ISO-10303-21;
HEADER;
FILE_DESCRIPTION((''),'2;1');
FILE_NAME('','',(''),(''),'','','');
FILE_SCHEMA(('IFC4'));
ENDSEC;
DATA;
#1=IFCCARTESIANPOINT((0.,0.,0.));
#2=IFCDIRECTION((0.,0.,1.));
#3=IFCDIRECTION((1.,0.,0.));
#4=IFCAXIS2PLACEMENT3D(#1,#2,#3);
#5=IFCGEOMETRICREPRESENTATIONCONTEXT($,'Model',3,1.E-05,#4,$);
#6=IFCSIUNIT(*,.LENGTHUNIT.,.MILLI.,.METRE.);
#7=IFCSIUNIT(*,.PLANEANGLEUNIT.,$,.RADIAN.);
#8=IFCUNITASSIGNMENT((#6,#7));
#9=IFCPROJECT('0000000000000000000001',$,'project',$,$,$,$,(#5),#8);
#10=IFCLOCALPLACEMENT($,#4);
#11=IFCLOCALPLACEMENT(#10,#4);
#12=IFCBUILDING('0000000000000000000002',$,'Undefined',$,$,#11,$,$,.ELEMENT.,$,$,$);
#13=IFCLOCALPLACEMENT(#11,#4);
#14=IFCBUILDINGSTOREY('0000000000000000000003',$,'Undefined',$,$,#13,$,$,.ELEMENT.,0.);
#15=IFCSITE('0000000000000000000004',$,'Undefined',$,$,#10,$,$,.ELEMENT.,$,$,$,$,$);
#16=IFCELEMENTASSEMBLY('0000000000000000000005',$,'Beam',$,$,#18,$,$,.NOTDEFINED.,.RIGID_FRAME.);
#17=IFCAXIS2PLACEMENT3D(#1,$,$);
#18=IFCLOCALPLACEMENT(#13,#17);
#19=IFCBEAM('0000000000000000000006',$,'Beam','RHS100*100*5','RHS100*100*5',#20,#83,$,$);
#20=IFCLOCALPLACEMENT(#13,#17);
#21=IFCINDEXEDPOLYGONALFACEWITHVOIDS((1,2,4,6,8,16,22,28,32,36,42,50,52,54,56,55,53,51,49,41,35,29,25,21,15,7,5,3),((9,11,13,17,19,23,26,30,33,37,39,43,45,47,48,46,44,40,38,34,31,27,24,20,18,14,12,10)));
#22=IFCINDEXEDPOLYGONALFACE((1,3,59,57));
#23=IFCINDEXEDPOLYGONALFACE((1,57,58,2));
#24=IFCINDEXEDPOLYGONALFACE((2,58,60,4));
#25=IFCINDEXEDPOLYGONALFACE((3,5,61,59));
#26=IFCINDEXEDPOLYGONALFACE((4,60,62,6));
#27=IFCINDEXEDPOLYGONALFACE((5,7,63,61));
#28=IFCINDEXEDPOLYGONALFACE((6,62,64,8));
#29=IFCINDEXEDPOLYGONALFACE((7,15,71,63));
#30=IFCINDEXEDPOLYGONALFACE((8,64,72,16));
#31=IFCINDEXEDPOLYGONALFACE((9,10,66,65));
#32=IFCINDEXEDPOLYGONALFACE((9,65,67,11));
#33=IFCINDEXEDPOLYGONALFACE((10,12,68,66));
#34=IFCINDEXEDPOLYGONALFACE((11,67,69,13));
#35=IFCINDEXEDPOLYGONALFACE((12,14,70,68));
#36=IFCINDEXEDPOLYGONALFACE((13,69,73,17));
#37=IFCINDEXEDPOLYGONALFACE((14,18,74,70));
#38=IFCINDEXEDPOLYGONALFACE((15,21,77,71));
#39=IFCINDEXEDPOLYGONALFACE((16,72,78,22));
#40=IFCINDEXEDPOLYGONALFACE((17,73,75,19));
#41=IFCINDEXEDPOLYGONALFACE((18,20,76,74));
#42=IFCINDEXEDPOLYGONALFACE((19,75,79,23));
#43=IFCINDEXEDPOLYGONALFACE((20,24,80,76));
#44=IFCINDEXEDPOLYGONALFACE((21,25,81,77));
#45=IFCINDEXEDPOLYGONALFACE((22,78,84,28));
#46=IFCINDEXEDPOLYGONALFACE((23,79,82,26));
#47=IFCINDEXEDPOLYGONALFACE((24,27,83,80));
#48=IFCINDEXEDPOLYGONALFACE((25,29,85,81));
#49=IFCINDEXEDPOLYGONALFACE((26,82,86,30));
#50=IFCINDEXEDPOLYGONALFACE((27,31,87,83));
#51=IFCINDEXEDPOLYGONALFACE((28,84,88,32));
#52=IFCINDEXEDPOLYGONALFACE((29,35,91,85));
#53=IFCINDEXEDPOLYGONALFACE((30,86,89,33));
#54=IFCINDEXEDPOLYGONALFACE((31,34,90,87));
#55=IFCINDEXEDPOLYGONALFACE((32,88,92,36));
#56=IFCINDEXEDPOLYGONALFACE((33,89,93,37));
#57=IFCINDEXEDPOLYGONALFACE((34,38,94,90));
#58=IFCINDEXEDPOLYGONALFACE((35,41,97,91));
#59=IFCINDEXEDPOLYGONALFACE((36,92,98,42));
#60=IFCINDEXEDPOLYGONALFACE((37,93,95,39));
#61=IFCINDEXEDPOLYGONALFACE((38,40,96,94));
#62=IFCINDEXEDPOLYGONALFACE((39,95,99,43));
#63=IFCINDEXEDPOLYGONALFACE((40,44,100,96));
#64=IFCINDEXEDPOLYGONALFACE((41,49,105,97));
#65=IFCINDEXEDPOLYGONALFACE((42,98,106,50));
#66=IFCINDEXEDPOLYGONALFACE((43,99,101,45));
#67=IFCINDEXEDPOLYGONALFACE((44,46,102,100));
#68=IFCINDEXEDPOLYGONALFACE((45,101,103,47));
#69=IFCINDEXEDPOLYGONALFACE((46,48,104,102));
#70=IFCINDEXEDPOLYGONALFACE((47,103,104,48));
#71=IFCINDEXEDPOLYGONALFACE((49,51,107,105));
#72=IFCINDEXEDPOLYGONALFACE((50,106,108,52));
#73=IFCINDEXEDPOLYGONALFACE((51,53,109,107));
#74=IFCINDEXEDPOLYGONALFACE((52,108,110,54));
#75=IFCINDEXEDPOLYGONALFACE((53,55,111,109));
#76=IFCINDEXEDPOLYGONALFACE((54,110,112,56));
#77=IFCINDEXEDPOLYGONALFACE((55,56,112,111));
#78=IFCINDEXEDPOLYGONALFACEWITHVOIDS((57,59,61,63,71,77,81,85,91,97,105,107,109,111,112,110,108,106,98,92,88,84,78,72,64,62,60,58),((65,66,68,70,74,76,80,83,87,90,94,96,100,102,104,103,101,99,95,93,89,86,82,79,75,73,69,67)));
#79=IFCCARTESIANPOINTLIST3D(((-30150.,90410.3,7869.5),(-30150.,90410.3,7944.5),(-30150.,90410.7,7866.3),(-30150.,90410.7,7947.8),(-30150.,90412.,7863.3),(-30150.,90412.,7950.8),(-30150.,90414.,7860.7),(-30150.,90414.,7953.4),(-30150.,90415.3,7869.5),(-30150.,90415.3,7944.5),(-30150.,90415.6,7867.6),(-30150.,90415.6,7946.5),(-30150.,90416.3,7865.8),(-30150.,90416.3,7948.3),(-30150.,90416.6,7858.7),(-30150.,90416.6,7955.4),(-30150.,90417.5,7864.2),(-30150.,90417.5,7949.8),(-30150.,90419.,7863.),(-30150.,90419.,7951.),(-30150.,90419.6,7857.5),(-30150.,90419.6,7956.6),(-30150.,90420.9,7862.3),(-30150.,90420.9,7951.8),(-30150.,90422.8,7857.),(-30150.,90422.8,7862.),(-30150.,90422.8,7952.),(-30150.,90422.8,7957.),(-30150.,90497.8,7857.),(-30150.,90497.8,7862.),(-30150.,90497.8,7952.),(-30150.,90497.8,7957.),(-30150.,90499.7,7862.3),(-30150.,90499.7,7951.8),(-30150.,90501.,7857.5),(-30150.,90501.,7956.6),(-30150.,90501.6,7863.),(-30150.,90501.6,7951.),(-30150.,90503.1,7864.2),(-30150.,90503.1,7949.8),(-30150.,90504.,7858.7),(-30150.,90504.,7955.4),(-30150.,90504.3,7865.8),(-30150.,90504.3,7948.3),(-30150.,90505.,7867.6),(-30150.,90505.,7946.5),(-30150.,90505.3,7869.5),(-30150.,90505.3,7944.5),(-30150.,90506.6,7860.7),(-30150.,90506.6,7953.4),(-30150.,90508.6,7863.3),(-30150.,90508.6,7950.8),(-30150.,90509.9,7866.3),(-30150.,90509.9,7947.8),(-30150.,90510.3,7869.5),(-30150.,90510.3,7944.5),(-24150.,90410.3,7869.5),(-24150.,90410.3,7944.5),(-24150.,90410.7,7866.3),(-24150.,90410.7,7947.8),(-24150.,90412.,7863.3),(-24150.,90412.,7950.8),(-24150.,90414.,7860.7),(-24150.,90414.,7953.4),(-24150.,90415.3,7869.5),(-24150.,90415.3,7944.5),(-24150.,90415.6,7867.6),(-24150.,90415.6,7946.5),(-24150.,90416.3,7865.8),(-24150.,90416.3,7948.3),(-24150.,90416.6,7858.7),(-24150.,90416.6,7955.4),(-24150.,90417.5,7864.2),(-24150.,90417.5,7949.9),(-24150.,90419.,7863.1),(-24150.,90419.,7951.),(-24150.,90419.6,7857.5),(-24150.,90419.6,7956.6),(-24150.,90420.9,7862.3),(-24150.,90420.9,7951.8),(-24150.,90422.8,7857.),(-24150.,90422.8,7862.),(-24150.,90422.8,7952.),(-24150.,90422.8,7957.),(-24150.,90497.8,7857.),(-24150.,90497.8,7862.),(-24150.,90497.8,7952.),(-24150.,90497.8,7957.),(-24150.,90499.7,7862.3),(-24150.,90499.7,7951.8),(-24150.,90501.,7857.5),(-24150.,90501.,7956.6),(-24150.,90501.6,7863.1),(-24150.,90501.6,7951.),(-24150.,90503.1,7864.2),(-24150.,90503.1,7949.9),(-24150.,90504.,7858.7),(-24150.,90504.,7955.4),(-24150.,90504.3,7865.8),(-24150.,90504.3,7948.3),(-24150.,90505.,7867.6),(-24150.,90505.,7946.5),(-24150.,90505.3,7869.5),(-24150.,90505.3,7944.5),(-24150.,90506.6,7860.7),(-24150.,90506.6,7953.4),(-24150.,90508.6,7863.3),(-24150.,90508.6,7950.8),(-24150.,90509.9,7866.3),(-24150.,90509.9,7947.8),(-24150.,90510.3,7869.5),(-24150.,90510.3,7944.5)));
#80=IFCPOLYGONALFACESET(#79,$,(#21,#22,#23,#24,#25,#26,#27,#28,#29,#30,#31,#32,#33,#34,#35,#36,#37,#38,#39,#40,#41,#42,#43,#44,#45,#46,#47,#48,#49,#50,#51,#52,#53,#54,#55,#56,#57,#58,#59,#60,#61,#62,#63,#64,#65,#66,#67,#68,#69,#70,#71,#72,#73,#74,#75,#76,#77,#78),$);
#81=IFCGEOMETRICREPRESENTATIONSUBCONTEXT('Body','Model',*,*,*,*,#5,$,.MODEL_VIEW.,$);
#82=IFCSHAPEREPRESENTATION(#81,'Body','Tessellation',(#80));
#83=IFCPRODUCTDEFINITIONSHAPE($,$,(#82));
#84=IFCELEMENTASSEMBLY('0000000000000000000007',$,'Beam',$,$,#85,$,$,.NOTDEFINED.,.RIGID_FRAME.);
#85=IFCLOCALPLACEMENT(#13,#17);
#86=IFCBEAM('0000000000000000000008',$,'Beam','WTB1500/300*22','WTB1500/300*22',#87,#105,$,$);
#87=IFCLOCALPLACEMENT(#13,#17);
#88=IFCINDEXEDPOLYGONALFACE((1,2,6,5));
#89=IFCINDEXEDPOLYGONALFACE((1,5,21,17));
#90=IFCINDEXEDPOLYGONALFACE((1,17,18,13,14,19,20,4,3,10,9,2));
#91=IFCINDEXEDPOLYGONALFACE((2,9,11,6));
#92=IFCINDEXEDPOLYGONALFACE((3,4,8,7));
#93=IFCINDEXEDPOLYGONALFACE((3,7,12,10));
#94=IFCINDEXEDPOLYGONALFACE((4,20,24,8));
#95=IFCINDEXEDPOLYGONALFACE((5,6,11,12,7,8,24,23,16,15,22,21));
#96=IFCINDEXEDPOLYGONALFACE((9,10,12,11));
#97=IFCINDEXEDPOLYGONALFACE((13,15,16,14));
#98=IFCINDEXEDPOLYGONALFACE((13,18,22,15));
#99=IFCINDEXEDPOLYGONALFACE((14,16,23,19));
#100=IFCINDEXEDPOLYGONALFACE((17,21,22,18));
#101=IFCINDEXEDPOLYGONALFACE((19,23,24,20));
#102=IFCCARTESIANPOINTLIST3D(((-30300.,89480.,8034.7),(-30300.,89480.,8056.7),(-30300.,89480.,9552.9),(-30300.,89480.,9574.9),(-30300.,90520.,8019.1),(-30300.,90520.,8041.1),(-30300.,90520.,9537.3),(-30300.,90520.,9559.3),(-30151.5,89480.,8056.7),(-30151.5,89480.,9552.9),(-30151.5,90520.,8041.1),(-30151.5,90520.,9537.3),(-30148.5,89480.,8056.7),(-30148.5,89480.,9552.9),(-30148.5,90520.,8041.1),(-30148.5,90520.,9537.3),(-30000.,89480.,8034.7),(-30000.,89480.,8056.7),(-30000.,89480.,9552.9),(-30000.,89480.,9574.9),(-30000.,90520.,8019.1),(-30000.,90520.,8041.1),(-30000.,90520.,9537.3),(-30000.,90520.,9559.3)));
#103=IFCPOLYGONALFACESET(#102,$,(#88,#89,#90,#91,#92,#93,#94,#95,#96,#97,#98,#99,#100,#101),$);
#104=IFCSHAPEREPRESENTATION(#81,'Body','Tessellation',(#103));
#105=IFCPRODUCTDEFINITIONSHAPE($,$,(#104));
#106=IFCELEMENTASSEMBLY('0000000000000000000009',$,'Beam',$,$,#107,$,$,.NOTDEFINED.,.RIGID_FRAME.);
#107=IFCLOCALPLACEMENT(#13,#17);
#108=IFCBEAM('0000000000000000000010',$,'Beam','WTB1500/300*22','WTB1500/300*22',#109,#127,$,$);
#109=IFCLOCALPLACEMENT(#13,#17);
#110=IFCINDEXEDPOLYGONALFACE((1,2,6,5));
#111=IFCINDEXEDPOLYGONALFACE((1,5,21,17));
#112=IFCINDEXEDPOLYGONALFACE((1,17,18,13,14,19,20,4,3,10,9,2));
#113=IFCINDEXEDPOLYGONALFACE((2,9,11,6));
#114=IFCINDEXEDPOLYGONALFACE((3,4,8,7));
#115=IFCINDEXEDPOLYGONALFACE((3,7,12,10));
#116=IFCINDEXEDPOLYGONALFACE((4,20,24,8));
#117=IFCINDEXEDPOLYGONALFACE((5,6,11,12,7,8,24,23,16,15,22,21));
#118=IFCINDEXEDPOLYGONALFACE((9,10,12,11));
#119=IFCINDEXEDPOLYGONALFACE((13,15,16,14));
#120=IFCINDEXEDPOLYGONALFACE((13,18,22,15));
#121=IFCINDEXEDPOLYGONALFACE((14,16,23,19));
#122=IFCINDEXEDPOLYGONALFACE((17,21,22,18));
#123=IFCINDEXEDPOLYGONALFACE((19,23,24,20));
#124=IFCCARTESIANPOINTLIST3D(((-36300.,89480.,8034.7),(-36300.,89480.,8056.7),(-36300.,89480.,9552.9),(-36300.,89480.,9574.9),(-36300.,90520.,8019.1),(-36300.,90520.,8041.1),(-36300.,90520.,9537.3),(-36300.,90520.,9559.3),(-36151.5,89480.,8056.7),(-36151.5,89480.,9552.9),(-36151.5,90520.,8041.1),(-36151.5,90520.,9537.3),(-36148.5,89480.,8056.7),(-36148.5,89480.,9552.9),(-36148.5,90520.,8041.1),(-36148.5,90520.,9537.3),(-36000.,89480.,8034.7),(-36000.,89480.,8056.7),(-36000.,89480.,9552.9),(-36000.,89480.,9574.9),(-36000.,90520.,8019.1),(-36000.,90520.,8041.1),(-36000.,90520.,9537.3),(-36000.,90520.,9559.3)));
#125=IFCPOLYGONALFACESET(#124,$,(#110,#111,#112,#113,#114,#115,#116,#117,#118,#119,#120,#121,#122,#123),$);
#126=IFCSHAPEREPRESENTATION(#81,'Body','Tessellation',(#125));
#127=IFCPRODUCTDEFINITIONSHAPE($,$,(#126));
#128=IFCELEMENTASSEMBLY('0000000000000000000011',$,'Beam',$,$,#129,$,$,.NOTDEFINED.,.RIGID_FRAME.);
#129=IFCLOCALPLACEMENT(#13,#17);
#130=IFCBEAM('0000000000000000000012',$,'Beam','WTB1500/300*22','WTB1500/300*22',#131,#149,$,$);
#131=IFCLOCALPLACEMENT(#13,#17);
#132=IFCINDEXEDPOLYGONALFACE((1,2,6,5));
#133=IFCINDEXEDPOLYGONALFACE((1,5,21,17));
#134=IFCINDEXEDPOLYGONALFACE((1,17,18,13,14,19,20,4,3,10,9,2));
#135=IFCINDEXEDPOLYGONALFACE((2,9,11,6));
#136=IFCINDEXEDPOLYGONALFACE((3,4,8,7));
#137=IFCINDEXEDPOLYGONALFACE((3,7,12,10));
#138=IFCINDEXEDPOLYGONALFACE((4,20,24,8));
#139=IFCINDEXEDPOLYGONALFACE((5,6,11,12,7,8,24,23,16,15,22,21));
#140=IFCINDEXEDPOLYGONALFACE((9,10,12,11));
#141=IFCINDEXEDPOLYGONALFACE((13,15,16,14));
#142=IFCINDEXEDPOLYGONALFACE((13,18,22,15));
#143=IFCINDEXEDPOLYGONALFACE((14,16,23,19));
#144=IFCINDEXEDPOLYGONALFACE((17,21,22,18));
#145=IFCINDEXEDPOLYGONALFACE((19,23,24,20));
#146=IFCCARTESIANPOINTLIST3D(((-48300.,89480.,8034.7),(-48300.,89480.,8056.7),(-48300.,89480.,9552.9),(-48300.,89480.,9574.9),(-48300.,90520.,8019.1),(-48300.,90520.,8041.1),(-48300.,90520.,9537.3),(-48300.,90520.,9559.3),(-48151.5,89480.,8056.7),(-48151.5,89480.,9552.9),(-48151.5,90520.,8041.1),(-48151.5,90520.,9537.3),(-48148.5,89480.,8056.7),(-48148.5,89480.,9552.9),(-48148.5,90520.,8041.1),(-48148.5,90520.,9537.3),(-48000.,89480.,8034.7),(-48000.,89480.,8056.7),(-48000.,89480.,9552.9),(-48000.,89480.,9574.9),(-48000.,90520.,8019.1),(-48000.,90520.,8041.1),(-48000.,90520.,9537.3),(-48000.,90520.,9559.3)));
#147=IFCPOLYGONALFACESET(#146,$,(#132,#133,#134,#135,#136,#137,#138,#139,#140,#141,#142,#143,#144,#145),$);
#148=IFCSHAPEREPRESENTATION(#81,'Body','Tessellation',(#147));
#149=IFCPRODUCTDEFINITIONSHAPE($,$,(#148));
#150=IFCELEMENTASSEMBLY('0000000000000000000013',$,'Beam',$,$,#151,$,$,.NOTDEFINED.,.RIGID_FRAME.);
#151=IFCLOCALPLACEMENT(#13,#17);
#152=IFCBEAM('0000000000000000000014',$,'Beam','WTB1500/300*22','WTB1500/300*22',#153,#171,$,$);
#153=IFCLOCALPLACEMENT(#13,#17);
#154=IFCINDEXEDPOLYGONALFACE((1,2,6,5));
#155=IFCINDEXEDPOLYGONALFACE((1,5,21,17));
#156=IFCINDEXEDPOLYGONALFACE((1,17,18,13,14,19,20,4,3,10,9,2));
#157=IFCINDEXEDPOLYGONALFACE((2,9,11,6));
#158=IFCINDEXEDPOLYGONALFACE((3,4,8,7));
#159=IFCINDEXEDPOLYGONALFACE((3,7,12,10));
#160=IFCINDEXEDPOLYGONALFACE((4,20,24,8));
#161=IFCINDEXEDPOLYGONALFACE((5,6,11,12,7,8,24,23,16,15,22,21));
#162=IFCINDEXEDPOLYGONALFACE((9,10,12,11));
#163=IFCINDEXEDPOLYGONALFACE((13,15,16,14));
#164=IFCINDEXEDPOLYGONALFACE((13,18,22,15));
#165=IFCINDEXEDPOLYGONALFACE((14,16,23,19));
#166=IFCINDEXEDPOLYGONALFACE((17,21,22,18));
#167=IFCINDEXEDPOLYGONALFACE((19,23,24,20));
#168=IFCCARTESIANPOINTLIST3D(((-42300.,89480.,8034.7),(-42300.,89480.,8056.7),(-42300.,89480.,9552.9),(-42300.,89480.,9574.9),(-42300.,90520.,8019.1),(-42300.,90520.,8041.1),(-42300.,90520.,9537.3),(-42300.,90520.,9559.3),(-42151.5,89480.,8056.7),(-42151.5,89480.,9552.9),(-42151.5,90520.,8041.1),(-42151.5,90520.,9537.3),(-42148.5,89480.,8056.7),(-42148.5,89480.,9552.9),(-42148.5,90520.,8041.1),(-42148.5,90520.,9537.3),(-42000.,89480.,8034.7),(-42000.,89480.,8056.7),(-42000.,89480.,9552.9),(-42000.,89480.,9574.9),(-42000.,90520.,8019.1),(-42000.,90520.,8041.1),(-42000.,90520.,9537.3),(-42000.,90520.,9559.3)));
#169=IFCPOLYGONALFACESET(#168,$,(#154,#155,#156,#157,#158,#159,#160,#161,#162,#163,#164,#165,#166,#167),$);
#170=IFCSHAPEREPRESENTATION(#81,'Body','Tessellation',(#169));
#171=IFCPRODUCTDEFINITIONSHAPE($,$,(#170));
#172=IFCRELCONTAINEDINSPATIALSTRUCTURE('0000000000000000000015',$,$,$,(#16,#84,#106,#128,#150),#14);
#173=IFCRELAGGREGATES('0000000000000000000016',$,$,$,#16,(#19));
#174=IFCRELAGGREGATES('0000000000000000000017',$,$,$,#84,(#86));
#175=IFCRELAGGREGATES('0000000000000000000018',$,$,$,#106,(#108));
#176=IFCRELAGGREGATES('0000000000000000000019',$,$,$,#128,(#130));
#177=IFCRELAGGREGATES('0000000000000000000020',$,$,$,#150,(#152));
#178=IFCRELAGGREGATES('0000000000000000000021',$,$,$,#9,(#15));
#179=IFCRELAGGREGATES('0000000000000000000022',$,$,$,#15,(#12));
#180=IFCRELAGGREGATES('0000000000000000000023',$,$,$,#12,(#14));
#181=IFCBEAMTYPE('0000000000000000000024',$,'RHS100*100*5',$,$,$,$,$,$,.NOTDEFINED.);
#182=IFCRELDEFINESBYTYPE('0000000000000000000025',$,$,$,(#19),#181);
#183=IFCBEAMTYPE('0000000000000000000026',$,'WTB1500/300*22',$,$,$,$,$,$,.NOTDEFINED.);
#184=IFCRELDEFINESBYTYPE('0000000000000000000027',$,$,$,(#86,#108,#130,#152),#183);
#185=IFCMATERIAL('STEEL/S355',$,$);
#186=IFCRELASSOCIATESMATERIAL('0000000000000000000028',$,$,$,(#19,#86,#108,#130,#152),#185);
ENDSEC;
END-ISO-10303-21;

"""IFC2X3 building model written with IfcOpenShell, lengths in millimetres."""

from ifc_helpers import new_model, si_unit, frame, origin_with_axes, origin_2d_with_axis, place, context, subcontext, project, spatial, polyline, hollow_rectangle, outline, extrude, clip, halfspace, material, type_object, element, aggregate, save


model = new_model("IFC2X3")

# Units and contexts
model_context = context("Model", 3, precision=1e-05, world=origin_with_axes())
body_context = subcontext(model_context, "Body", "Model", "MODEL_VIEW")
ifc_project = project(units=[si_unit("LENGTHUNIT", "METRE", prefix="MILLI"), si_unit("PLANEANGLEUNIT", "RADIAN")], contexts=[model_context])

# Site, building, storey
site_placement = place(None, origin_with_axes())
site = spatial("IfcSite", under=ifc_project, at=site_placement, Name="Undefined", CompositionType="ELEMENT")
building_placement = place(site_placement, origin_with_axes())
building = spatial("IfcBuilding", under=site, at=building_placement, Name="Undefined", CompositionType="ELEMENT")
storey_placement = place(building_placement, origin_with_axes())
storey = spatial("IfcBuildingStorey", under=building, at=storey_placement, Name="Undefined", CompositionType="ELEMENT", Elevation=0.0)

# Element assemblies, beams
ifc_material_1 = material(Name="STEEL/S355")
beam_type_1 = type_object("IfcBeamType", Name="RHS100*100*5", PredefinedType="NOTDEFINED")
assembly_1_placement = place(storey_placement, origin_with_axes())
assembly_1 = element("IfcElementAssembly", 1, at=assembly_1_placement, inside=storey, Name="Beam", AssemblyPlace="NOTDEFINED", PredefinedType="RIGID_FRAME")
beam_1_placement = place(assembly_1_placement, frame((-24150.0, 90460.3, 7907.0), z_axis=(-0.000002, 0.0, 1.0), x_axis=(-1.0, 0.0, -0.000002)))
beam_1 = element("IfcBeam", 2, at=beam_1_placement, type_object=beam_type_1, material=ifc_material_1, Name="Beam", Description="RHS100*100*5", ObjectType="RHS100*100*5", context=body_context, shape_type="SweptSolid", body=[
    extrude(hollow_rectangle(XDim=100.0, YDim=100.0, WallThickness=5.0, InnerFilletRadius=7.5, OuterFilletRadius=12.5, at=origin_2d_with_axis()), frame((6000.0, 0.0, 0.0), z_axis=(-1.0, 0.0, 0.0), x_axis=(0.0, -1.0, 0.0)), (0.0, 0.0, 1.0), 6000.0),
])
aggregate(assembly_1, [beam_1])
assembly_2_placement = place(storey_placement, origin_with_axes())
assembly_2 = element("IfcElementAssembly", 3, at=assembly_2_placement, inside=storey, Name="Beam", AssemblyPlace="NOTDEFINED", PredefinedType="RIGID_FRAME")
beam_type_2 = type_object("IfcBeamType", Name="WTB1500/300*22", PredefinedType="NOTDEFINED")
beam_2_placement = place(assembly_2_placement, frame((-30150.0, 91100.1, 8780.5), z_axis=(0.0, 0.014993, 0.999888), x_axis=(0.0, -0.999888, 0.014993)))
beam_2 = element("IfcBeam", 4, at=beam_2_placement, type_object=beam_type_2, material=ifc_material_1, Name="Beam", Description="WTB1500/300*22", ObjectType="WTB1500/300*22", context=body_context, shape_type="Clipping", body=[
    clip(clip(extrude(outline(polyline([(-1.5, 748.0), (-150.0, 748.0), (-150.0, 770.0), (150.0, 770.0), (150.0, 748.0), (1.5, 748.0), (1.5, -748.0), (150.0, -748.0), (150.0, -770.0), (-150.0, -770.0), (-150.0, -748.0), (-1.5, -748.0), (-1.5, 748.0)])), frame((1643.7, 0.0, 0.0), z_axis=(-1.0, 0.0, 0.0), x_axis=(0.0, -1.0, 0.0)), (0.0, 0.0, 1.0), 1643.7), halfspace(frame((591.8, -150.0, 770.0), z_axis=(-0.999888, 0.0, 0.014993), x_axis=(-0.014993, 0.0, -0.999888)), False)), halfspace(frame((1631.9, 150.0, 770.0), z_axis=(0.999888, 0.0, -0.014993), x_axis=(-0.014993, 0.0, -0.999888)), False)),
])
aggregate(assembly_2, [beam_2])
assembly_3_placement = place(storey_placement, origin_with_axes())
assembly_3 = element("IfcElementAssembly", 5, at=assembly_3_placement, inside=storey, Name="Beam", AssemblyPlace="NOTDEFINED", PredefinedType="RIGID_FRAME")
beam_3_placement = place(assembly_3_placement, frame((-36150.0, 91100.1, 8780.5), z_axis=(0.0, 0.014993, 0.999888), x_axis=(0.0, -0.999888, 0.014993)))
beam_3 = element("IfcBeam", 6, at=beam_3_placement, type_object=beam_type_2, material=ifc_material_1, Name="Beam", Description="WTB1500/300*22", ObjectType="WTB1500/300*22", context=body_context, shape_type="Clipping", body=[
    clip(clip(extrude(outline(polyline([(-1.5, 748.0), (-150.0, 748.0), (-150.0, 770.0), (150.0, 770.0), (150.0, 748.0), (1.5, 748.0), (1.5, -748.0), (150.0, -748.0), (150.0, -770.0), (-150.0, -770.0), (-150.0, -748.0), (-1.5, -748.0), (-1.5, 748.0)])), frame((1643.7, 0.0, 0.0), z_axis=(-1.0, 0.0, 0.0), x_axis=(0.0, -1.0, 0.0)), (0.0, 0.0, 1.0), 1643.7), halfspace(frame((591.8, -150.0, 770.0), z_axis=(-0.999888, 0.0, 0.014993), x_axis=(-0.014993, 0.0, -0.999888)), False)), halfspace(frame((1631.9, 150.0, 770.0), z_axis=(0.999888, 0.0, -0.014993), x_axis=(-0.014993, 0.0, -0.999888)), False)),
])
aggregate(assembly_3, [beam_3])
assembly_4_placement = place(storey_placement, origin_with_axes())
assembly_4 = element("IfcElementAssembly", 7, at=assembly_4_placement, inside=storey, Name="Beam", AssemblyPlace="NOTDEFINED", PredefinedType="RIGID_FRAME")
beam_4_placement = place(assembly_4_placement, frame((-48150.0, 91100.1, 8780.5), z_axis=(0.0, 0.014993, 0.999888), x_axis=(0.0, -0.999888, 0.014993)))
beam_4 = element("IfcBeam", 8, at=beam_4_placement, type_object=beam_type_2, material=ifc_material_1, Name="Beam", Description="WTB1500/300*22", ObjectType="WTB1500/300*22", context=body_context, shape_type="Clipping", body=[
    clip(clip(extrude(outline(polyline([(-1.5, 748.0), (-150.0, 748.0), (-150.0, 770.0), (150.0, 770.0), (150.0, 748.0), (1.5, 748.0), (1.5, -748.0), (150.0, -748.0), (150.0, -770.0), (-150.0, -770.0), (-150.0, -748.0), (-1.5, -748.0), (-1.5, 748.0)])), frame((1643.7, 0.0, 0.0), z_axis=(-1.0, 0.0, 0.0), x_axis=(0.0, -1.0, 0.0)), (0.0, 0.0, 1.0), 1643.7), halfspace(frame((591.8, -150.0, 770.0), z_axis=(-0.999888, 0.0, 0.014993), x_axis=(-0.014993, 0.0, -0.999888)), False)), halfspace(frame((1631.9, 150.0, 770.0), z_axis=(0.999888, 0.0, -0.014993), x_axis=(-0.014993, 0.0, -0.999888)), False)),
])
aggregate(assembly_4, [beam_4])
assembly_5_placement = place(storey_placement, origin_with_axes())
assembly_5 = element("IfcElementAssembly", 9, at=assembly_5_placement, inside=storey, Name="Beam", AssemblyPlace="NOTDEFINED", PredefinedType="RIGID_FRAME")
beam_5_placement = place(assembly_5_placement, frame((-42150.0, 91100.1, 8780.5), z_axis=(0.0, 0.014993, 0.999888), x_axis=(0.0, -0.999888, 0.014993)))
beam_5 = element("IfcBeam", 10, at=beam_5_placement, type_object=beam_type_2, material=ifc_material_1, Name="Beam", Description="WTB1500/300*22", ObjectType="WTB1500/300*22", context=body_context, shape_type="Clipping", body=[
    clip(clip(extrude(outline(polyline([(-1.5, 748.0), (-150.0, 748.0), (-150.0, 770.0), (150.0, 770.0), (150.0, 748.0), (1.5, 748.0), (1.5, -748.0), (150.0, -748.0), (150.0, -770.0), (-150.0, -770.0), (-150.0, -748.0), (-1.5, -748.0), (-1.5, 748.0)])), frame((1643.7, 0.0, 0.0), z_axis=(-1.0, 0.0, 0.0), x_axis=(0.0, -1.0, 0.0)), (0.0, 0.0, 1.0), 1643.7), halfspace(frame((591.8, -150.0, 770.0), z_axis=(-0.999888, 0.0, 0.014993), x_axis=(-0.014993, 0.0, -0.999888)), False)), halfspace(frame((1631.9, 150.0, 770.0), z_axis=(0.999888, 0.0, -0.014993), x_axis=(-0.014993, 0.0, -0.999888)), False)),
])
aggregate(assembly_5, [beam_5])

save(model, "model.ifc")
